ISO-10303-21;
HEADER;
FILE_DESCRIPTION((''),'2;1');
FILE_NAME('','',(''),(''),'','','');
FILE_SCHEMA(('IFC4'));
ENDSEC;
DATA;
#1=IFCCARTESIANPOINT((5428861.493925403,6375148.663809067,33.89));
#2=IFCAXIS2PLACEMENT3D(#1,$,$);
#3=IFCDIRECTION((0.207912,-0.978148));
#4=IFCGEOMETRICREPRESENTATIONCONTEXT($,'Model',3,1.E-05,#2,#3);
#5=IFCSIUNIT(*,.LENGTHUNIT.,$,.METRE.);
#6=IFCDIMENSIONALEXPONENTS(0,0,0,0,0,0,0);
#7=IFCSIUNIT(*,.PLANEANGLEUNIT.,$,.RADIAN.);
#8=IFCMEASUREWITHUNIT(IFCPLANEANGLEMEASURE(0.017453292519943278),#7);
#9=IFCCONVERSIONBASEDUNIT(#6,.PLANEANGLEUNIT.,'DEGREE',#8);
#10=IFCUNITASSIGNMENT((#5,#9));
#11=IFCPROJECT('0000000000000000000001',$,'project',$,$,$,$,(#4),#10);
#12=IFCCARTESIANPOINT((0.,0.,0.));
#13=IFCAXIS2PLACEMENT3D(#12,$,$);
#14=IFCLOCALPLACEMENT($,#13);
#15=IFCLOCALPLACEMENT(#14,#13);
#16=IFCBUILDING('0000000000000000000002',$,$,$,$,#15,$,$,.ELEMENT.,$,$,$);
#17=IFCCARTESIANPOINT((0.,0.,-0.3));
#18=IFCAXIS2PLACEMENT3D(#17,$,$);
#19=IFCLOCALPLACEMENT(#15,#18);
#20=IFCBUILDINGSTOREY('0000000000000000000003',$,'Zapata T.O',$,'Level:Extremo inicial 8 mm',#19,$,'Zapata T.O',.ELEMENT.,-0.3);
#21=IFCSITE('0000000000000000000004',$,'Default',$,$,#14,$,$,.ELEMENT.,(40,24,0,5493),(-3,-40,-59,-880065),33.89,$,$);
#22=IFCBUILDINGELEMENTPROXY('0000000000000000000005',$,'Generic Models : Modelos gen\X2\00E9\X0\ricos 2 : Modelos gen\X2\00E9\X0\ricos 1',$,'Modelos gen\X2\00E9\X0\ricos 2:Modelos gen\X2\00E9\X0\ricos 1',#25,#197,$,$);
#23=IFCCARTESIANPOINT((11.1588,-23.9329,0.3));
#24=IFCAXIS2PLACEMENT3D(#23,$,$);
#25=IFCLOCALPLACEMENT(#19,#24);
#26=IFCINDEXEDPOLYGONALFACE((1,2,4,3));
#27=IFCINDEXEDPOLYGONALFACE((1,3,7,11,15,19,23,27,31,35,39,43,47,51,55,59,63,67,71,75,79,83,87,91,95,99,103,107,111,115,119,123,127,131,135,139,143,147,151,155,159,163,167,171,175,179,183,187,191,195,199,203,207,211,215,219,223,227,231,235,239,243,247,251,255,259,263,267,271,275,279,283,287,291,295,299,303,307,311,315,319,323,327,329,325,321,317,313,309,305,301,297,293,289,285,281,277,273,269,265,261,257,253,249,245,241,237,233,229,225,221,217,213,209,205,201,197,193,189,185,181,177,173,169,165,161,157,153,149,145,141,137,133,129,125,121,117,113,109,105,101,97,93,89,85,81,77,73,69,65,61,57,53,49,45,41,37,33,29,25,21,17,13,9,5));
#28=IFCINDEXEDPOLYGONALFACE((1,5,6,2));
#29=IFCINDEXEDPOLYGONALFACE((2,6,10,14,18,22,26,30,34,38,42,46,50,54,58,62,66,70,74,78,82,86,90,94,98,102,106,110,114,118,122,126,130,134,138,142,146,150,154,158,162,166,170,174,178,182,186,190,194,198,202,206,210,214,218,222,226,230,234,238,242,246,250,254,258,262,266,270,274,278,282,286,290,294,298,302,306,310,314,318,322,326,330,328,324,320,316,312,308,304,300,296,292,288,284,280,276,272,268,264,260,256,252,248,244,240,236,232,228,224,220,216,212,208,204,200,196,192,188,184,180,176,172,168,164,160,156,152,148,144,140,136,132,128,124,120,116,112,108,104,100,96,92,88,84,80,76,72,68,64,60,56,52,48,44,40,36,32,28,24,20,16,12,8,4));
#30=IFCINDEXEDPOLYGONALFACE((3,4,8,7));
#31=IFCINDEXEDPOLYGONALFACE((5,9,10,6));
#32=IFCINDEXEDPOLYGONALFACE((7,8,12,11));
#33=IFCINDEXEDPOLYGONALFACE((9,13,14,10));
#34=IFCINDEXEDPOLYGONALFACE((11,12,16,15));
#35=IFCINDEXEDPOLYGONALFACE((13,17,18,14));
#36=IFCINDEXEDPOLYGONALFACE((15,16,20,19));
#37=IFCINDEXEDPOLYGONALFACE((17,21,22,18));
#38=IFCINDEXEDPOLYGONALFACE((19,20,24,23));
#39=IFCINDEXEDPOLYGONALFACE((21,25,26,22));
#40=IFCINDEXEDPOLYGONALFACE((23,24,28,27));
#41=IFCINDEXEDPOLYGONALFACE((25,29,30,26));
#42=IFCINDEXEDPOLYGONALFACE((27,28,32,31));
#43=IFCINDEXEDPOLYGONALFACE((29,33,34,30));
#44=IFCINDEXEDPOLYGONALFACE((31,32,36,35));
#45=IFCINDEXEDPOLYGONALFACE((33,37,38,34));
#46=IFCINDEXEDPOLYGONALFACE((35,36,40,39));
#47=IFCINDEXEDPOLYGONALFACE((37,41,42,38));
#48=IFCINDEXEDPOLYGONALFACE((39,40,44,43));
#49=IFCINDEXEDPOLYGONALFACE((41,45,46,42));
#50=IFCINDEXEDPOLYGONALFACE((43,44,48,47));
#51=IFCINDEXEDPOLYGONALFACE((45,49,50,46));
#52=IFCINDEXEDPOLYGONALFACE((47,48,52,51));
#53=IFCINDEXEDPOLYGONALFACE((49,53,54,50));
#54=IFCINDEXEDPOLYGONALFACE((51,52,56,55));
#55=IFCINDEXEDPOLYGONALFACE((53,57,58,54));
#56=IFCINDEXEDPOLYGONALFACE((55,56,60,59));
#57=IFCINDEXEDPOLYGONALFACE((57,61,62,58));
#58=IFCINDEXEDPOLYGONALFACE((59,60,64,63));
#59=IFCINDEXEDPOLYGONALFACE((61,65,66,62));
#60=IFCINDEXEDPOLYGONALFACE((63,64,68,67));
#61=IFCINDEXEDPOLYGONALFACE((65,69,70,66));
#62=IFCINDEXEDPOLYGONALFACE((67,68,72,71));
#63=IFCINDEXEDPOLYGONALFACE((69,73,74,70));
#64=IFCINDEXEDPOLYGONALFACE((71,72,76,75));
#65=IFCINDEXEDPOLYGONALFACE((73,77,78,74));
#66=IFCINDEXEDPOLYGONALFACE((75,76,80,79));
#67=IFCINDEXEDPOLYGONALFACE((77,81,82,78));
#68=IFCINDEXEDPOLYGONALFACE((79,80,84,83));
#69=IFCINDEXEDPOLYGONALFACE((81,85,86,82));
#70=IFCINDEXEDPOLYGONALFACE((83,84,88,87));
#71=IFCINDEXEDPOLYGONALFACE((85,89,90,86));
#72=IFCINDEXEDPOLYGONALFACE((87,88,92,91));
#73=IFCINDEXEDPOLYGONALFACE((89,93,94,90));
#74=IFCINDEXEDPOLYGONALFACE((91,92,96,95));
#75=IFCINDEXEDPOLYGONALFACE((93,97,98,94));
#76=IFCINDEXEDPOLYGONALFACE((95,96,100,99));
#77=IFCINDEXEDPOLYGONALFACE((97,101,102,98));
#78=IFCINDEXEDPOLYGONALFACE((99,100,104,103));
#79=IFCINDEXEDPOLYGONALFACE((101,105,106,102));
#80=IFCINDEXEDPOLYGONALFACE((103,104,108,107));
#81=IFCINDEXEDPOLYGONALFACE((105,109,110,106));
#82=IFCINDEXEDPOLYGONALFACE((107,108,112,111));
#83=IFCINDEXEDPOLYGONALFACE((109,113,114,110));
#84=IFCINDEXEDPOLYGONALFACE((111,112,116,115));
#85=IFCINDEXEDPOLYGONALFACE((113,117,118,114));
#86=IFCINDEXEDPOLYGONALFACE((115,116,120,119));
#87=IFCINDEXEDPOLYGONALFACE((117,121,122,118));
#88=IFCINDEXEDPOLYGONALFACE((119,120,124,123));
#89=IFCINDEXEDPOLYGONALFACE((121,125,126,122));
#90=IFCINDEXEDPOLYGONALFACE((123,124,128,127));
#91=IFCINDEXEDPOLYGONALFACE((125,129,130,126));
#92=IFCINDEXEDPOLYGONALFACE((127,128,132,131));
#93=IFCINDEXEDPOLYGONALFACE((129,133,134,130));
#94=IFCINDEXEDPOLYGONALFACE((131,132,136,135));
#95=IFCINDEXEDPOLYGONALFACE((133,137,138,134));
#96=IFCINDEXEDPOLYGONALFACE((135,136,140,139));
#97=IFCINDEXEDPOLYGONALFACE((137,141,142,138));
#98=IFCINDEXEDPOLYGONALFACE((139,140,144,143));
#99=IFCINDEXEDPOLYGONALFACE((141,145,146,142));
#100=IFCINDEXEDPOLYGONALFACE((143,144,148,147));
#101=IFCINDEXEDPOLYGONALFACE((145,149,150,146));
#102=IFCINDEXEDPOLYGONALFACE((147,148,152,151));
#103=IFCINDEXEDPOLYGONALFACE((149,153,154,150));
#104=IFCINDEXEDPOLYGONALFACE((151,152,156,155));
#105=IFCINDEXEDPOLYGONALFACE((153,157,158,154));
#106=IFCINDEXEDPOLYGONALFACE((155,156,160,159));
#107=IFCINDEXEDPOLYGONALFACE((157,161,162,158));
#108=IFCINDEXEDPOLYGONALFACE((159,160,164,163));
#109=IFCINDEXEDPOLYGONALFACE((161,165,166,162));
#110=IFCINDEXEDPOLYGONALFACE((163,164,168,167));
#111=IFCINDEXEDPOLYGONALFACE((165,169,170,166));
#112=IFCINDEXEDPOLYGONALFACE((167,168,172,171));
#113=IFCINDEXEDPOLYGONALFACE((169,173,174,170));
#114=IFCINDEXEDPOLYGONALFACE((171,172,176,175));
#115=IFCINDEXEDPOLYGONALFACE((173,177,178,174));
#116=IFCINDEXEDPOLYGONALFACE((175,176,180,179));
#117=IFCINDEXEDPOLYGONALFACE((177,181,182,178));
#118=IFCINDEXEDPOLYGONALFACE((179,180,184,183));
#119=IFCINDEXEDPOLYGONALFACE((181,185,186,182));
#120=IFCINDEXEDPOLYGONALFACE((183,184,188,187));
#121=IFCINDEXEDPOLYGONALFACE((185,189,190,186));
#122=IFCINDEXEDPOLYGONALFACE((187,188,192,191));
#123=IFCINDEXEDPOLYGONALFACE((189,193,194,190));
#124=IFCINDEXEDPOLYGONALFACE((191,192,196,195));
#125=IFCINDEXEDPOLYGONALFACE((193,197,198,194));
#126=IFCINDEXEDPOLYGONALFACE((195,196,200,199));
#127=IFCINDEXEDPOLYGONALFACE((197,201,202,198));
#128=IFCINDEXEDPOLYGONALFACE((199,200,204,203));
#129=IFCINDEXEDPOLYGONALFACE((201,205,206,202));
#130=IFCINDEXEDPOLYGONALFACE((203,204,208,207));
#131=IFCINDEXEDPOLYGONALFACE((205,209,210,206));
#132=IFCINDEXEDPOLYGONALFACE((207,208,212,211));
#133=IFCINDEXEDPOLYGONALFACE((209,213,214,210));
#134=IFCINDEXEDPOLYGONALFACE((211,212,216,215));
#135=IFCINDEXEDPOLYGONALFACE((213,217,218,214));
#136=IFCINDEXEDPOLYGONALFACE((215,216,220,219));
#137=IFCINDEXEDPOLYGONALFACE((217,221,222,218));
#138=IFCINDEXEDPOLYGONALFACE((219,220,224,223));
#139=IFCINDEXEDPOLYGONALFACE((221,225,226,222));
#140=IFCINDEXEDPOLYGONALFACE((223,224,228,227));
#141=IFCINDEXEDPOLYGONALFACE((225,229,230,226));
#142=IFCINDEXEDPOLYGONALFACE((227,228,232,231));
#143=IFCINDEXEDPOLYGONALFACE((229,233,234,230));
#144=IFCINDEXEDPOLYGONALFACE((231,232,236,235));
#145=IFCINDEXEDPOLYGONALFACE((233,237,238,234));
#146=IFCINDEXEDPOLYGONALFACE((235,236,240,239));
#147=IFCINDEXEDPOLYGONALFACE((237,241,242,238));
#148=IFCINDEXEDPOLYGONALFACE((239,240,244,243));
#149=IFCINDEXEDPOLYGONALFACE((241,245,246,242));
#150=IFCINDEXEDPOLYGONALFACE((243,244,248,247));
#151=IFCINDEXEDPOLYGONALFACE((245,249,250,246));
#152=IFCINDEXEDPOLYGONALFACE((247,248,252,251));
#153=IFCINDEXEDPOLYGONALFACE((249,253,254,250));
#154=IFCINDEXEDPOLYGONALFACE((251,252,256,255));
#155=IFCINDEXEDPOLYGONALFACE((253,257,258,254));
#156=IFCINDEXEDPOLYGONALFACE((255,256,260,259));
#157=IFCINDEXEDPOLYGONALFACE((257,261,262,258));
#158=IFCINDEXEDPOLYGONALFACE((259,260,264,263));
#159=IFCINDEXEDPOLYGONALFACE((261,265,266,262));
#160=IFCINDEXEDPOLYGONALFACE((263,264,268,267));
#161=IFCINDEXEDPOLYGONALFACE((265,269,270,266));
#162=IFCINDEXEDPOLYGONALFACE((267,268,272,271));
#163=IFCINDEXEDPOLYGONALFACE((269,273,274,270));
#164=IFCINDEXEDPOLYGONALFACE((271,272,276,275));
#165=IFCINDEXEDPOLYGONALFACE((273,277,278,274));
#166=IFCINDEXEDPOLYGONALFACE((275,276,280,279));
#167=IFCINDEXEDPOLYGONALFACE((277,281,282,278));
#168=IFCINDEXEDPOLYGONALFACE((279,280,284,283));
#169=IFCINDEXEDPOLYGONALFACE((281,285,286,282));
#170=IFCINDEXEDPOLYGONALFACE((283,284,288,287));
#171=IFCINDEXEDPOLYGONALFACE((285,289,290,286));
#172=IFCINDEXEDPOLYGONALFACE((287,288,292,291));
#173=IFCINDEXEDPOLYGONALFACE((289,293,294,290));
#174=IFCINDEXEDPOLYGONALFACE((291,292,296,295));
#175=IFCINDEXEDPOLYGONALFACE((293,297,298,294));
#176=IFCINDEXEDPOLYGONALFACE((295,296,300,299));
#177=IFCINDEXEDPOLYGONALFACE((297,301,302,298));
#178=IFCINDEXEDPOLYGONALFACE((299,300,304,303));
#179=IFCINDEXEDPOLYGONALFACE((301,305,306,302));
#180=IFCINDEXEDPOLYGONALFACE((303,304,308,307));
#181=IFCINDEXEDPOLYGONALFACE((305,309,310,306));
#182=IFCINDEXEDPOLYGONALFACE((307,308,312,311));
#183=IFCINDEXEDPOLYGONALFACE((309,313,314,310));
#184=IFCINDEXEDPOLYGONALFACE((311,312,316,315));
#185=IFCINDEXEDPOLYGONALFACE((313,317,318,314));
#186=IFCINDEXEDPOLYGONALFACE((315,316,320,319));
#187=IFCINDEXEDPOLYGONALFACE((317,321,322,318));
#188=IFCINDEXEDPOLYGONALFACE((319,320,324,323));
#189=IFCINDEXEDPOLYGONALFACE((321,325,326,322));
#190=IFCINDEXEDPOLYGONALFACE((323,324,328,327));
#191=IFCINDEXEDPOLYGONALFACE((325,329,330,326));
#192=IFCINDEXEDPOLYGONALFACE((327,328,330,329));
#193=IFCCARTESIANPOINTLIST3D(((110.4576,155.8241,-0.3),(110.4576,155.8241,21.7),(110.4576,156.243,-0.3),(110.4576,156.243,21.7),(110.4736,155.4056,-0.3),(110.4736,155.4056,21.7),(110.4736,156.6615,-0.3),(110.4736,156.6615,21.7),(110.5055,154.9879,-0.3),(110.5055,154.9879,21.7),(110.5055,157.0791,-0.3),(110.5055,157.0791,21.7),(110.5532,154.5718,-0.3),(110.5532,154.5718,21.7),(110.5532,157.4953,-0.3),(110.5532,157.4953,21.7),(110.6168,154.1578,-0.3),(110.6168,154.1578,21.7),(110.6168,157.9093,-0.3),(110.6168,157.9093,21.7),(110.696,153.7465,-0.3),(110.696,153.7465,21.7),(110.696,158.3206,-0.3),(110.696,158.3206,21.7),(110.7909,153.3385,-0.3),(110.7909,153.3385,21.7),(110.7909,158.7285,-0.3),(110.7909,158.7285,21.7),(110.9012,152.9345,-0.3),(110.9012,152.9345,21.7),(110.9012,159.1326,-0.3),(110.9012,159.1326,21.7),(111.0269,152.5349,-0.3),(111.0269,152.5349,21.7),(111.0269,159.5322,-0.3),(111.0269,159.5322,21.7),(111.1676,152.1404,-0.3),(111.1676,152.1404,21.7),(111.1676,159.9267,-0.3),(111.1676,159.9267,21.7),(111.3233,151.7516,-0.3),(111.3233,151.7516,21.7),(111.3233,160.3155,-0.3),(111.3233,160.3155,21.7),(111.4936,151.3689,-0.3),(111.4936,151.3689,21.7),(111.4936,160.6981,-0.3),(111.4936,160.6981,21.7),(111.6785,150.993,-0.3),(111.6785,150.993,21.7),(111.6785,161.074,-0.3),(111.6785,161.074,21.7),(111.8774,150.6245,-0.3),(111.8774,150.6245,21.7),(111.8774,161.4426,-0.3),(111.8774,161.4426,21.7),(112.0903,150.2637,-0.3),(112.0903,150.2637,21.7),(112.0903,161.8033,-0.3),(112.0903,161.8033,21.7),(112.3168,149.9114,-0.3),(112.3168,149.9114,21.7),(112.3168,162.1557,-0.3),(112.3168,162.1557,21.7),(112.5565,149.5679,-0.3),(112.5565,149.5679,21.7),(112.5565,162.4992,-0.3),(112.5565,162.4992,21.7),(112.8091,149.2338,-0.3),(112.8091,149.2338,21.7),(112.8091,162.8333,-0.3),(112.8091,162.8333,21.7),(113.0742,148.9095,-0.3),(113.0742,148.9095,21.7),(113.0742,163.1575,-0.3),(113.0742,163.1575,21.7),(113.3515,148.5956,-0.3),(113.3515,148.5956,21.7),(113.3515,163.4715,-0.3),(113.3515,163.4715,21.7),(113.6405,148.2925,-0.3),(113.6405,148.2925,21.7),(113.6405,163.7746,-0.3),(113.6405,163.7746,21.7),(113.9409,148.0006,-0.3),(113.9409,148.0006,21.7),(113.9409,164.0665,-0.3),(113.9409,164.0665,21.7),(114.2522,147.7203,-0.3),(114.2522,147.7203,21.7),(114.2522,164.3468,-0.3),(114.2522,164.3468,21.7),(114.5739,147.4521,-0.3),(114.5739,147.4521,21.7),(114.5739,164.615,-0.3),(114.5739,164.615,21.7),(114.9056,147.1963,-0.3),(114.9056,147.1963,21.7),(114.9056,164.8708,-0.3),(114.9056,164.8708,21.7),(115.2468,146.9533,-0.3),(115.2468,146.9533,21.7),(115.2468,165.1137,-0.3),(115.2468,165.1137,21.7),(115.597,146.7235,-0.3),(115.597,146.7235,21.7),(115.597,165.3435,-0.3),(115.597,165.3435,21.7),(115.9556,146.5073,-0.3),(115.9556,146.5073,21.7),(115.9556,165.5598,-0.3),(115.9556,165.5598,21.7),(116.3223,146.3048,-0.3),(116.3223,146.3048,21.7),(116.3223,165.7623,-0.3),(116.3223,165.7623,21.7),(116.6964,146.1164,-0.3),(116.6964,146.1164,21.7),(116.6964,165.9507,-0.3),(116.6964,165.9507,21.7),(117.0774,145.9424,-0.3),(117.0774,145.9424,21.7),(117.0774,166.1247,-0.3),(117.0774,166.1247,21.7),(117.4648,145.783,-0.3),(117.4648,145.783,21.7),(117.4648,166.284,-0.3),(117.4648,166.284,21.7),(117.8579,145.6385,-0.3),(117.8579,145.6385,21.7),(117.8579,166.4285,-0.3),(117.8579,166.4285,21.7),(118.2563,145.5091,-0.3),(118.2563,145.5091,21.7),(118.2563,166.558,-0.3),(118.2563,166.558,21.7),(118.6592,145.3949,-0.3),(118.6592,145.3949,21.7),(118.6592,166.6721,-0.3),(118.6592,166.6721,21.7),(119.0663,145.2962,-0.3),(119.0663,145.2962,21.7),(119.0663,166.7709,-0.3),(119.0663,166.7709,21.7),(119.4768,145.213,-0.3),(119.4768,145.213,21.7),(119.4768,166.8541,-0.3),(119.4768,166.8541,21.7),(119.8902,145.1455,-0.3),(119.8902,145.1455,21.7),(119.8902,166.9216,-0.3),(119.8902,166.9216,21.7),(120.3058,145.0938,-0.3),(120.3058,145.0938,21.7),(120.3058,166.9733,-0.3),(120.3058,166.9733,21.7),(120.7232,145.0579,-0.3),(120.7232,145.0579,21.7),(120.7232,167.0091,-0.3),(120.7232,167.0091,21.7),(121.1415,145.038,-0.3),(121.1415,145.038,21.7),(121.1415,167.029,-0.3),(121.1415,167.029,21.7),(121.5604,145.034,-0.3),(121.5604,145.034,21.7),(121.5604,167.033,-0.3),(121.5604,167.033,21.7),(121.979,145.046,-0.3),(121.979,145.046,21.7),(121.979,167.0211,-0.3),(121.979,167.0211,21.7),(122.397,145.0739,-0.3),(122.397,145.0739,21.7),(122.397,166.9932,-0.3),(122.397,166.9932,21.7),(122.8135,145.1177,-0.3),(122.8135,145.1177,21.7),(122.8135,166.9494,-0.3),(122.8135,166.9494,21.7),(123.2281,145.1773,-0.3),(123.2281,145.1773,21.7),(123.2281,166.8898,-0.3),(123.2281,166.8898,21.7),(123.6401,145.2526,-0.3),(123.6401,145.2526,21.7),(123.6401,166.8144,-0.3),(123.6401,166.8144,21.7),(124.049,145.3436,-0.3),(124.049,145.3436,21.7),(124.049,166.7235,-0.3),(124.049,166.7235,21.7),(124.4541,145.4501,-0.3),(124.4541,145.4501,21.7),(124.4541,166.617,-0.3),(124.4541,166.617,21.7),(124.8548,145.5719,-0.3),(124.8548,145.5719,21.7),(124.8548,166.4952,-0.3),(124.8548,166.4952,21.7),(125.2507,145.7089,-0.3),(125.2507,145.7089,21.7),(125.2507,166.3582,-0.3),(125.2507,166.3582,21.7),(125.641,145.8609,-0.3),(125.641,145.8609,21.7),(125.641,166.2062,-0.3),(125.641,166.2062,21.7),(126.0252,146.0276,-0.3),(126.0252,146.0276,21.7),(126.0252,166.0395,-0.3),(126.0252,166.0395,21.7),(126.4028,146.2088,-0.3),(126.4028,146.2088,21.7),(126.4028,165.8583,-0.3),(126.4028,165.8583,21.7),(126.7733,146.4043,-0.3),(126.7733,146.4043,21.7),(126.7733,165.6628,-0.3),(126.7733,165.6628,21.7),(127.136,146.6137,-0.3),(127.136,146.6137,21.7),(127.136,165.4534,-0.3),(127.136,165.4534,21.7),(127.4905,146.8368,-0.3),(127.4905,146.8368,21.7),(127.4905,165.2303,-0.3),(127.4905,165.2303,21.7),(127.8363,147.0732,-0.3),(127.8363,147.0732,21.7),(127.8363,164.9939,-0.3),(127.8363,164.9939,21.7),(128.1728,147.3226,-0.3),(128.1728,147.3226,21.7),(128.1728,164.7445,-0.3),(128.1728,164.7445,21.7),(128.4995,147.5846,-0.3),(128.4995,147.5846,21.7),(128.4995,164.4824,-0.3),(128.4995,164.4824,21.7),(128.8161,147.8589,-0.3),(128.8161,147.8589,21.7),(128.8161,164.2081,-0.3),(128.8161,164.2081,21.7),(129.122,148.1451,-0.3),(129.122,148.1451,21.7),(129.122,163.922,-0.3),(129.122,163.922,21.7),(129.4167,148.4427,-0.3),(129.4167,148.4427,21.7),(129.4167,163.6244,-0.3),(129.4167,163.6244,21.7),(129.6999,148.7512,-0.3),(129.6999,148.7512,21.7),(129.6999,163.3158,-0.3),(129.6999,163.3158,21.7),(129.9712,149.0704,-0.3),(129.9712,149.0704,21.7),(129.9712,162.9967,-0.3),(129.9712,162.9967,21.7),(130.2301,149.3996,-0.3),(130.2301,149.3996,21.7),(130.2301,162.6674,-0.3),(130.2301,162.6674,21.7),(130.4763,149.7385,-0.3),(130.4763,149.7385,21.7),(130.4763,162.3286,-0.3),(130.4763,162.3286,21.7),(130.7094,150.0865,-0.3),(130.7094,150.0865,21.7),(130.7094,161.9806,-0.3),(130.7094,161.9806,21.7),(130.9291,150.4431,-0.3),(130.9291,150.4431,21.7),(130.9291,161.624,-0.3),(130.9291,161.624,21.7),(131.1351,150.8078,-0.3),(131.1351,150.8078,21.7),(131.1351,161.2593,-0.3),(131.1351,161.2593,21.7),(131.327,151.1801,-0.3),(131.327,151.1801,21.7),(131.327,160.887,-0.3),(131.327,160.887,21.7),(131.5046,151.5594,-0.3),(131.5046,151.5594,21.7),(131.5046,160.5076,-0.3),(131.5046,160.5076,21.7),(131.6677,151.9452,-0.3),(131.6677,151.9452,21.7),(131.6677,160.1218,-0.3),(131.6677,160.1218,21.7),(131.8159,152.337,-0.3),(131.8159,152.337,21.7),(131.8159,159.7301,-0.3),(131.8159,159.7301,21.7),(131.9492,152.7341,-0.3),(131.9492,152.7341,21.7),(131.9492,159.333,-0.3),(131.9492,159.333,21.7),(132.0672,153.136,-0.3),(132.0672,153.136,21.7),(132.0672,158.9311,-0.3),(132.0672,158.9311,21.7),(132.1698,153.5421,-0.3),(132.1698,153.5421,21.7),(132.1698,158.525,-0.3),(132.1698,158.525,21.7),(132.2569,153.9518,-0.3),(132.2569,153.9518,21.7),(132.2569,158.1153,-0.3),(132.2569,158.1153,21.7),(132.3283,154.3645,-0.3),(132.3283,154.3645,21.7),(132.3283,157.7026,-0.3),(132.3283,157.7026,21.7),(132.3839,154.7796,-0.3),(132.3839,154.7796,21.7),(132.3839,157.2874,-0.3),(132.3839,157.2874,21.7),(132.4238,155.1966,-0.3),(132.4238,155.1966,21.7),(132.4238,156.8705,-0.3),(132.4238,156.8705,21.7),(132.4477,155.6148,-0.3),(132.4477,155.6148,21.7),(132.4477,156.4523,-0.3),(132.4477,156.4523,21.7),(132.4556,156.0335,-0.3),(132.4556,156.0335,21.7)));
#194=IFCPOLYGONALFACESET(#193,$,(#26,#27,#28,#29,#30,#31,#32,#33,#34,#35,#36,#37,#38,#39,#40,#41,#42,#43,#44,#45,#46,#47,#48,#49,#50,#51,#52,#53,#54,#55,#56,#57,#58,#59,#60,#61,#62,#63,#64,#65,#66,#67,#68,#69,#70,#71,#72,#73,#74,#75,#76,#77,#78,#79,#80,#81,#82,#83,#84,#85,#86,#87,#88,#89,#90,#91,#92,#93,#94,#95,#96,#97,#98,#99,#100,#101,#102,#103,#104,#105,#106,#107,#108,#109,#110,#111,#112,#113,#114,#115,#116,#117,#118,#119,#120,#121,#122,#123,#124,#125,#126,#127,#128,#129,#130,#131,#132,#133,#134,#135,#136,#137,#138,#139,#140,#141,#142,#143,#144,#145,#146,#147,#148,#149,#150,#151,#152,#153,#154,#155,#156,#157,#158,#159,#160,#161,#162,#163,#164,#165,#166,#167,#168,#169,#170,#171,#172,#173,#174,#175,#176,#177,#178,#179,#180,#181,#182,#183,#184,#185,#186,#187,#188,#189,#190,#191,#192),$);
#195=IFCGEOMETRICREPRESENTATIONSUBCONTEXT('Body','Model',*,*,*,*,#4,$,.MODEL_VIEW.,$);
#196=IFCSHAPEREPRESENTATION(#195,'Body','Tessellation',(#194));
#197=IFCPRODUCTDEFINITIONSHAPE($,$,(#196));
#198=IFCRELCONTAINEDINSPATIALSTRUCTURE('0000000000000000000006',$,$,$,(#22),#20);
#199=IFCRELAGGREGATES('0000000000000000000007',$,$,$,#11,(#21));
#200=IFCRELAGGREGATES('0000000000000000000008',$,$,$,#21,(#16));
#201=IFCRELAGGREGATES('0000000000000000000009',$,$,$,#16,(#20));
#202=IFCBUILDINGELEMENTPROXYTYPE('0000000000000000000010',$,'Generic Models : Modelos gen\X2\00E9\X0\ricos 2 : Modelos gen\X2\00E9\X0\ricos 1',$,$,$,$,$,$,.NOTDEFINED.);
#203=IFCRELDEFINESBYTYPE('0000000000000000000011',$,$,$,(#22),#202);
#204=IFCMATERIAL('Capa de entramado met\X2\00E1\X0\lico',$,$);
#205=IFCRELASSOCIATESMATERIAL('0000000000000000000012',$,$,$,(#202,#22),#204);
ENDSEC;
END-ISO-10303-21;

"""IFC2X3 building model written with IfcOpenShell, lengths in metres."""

from ifc_helpers import new_model, entity, si_unit, converted_unit, direction, frame, frame_2d, origin, place, context, subcontext, project, spatial, circle, extrude, source, transform, mapped, material, type_object, type_shapes, element, save


model = new_model("IFC2X3")

# Units and contexts
model_context = context("Model", 3, precision=1e-05, world=frame((5428861.493925403, 6375148.663809067, 33.89)), true_north=direction((0.207912, -0.978148)))
body_context = subcontext(model_context, "Body", "Model", "MODEL_VIEW")
ifc_project = project(units=[si_unit("LENGTHUNIT", "METRE"), converted_unit("PLANEANGLEUNIT", "DEGREE", entity("IfcPlaneAngleMeasure", 0.017453292519943278), si_unit("PLANEANGLEUNIT", "RADIAN"), dimensions=[0, 0, 0, 0, 0, 0, 0])], contexts=[model_context])

# Site, building, storey
site_placement = place(None, origin())
site = spatial("IfcSite", under=ifc_project, at=site_placement, Name="Default", CompositionType="ELEMENT", RefLatitude=(40, 24, 0, 5493), RefLongitude=(-3, -40, -59, -880065), RefElevation=33.89)
building_placement = place(site_placement, origin())
building = spatial("IfcBuilding", under=site, at=building_placement, CompositionType="ELEMENT")
storey_placement = place(building_placement, frame((0.0, 0.0, -0.3)))
storey = spatial("IfcBuildingStorey", under=building, at=storey_placement, Name="Zapata T.O", ObjectType="Level:Extremo inicial 8 mm", LongName="Zapata T.O", CompositionType="ELEMENT", Elevation=-0.3)

# Building element proxy
ifc_material = material(Name="Capa de entramado metálico")
building_element_proxy_type_1 = type_object("IfcBuildingElementProxyType", Name="Generic Models : Modelos genéricos 2 : Modelos genéricos 1", PredefinedType="NOTDEFINED", material=ifc_material)
shared_shape_1 = source(origin(), body_context, "Body", "SweptSolid", [
    extrude(circle(Radius=11.0, at=frame_2d((0.0, 0.0), x_axis=(1.0, 0.0))), frame((121.4556, 156.0335, -0.3)), (0.0, 0.0, 1.0), 22.0),
])
type_shapes(building_element_proxy_type_1, [shared_shape_1])
proxy_1_placement = place(storey_placement, frame((11.1588, -23.9329, 0.3)))
element("IfcBuildingElementProxy", 1, at=proxy_1_placement, inside=storey, type_object=building_element_proxy_type_1, material=ifc_material, Name="Generic Models : Modelos genéricos 2 : Modelos genéricos 1", ObjectType="Modelos genéricos 2:Modelos genéricos 1", context=body_context, shape_type="MappedRepresentation", body=[
    mapped(shared_shape_1, transform((0.0, 0.0, 0.0), scale=1.0)),
])

save(model, "model.ifc")
